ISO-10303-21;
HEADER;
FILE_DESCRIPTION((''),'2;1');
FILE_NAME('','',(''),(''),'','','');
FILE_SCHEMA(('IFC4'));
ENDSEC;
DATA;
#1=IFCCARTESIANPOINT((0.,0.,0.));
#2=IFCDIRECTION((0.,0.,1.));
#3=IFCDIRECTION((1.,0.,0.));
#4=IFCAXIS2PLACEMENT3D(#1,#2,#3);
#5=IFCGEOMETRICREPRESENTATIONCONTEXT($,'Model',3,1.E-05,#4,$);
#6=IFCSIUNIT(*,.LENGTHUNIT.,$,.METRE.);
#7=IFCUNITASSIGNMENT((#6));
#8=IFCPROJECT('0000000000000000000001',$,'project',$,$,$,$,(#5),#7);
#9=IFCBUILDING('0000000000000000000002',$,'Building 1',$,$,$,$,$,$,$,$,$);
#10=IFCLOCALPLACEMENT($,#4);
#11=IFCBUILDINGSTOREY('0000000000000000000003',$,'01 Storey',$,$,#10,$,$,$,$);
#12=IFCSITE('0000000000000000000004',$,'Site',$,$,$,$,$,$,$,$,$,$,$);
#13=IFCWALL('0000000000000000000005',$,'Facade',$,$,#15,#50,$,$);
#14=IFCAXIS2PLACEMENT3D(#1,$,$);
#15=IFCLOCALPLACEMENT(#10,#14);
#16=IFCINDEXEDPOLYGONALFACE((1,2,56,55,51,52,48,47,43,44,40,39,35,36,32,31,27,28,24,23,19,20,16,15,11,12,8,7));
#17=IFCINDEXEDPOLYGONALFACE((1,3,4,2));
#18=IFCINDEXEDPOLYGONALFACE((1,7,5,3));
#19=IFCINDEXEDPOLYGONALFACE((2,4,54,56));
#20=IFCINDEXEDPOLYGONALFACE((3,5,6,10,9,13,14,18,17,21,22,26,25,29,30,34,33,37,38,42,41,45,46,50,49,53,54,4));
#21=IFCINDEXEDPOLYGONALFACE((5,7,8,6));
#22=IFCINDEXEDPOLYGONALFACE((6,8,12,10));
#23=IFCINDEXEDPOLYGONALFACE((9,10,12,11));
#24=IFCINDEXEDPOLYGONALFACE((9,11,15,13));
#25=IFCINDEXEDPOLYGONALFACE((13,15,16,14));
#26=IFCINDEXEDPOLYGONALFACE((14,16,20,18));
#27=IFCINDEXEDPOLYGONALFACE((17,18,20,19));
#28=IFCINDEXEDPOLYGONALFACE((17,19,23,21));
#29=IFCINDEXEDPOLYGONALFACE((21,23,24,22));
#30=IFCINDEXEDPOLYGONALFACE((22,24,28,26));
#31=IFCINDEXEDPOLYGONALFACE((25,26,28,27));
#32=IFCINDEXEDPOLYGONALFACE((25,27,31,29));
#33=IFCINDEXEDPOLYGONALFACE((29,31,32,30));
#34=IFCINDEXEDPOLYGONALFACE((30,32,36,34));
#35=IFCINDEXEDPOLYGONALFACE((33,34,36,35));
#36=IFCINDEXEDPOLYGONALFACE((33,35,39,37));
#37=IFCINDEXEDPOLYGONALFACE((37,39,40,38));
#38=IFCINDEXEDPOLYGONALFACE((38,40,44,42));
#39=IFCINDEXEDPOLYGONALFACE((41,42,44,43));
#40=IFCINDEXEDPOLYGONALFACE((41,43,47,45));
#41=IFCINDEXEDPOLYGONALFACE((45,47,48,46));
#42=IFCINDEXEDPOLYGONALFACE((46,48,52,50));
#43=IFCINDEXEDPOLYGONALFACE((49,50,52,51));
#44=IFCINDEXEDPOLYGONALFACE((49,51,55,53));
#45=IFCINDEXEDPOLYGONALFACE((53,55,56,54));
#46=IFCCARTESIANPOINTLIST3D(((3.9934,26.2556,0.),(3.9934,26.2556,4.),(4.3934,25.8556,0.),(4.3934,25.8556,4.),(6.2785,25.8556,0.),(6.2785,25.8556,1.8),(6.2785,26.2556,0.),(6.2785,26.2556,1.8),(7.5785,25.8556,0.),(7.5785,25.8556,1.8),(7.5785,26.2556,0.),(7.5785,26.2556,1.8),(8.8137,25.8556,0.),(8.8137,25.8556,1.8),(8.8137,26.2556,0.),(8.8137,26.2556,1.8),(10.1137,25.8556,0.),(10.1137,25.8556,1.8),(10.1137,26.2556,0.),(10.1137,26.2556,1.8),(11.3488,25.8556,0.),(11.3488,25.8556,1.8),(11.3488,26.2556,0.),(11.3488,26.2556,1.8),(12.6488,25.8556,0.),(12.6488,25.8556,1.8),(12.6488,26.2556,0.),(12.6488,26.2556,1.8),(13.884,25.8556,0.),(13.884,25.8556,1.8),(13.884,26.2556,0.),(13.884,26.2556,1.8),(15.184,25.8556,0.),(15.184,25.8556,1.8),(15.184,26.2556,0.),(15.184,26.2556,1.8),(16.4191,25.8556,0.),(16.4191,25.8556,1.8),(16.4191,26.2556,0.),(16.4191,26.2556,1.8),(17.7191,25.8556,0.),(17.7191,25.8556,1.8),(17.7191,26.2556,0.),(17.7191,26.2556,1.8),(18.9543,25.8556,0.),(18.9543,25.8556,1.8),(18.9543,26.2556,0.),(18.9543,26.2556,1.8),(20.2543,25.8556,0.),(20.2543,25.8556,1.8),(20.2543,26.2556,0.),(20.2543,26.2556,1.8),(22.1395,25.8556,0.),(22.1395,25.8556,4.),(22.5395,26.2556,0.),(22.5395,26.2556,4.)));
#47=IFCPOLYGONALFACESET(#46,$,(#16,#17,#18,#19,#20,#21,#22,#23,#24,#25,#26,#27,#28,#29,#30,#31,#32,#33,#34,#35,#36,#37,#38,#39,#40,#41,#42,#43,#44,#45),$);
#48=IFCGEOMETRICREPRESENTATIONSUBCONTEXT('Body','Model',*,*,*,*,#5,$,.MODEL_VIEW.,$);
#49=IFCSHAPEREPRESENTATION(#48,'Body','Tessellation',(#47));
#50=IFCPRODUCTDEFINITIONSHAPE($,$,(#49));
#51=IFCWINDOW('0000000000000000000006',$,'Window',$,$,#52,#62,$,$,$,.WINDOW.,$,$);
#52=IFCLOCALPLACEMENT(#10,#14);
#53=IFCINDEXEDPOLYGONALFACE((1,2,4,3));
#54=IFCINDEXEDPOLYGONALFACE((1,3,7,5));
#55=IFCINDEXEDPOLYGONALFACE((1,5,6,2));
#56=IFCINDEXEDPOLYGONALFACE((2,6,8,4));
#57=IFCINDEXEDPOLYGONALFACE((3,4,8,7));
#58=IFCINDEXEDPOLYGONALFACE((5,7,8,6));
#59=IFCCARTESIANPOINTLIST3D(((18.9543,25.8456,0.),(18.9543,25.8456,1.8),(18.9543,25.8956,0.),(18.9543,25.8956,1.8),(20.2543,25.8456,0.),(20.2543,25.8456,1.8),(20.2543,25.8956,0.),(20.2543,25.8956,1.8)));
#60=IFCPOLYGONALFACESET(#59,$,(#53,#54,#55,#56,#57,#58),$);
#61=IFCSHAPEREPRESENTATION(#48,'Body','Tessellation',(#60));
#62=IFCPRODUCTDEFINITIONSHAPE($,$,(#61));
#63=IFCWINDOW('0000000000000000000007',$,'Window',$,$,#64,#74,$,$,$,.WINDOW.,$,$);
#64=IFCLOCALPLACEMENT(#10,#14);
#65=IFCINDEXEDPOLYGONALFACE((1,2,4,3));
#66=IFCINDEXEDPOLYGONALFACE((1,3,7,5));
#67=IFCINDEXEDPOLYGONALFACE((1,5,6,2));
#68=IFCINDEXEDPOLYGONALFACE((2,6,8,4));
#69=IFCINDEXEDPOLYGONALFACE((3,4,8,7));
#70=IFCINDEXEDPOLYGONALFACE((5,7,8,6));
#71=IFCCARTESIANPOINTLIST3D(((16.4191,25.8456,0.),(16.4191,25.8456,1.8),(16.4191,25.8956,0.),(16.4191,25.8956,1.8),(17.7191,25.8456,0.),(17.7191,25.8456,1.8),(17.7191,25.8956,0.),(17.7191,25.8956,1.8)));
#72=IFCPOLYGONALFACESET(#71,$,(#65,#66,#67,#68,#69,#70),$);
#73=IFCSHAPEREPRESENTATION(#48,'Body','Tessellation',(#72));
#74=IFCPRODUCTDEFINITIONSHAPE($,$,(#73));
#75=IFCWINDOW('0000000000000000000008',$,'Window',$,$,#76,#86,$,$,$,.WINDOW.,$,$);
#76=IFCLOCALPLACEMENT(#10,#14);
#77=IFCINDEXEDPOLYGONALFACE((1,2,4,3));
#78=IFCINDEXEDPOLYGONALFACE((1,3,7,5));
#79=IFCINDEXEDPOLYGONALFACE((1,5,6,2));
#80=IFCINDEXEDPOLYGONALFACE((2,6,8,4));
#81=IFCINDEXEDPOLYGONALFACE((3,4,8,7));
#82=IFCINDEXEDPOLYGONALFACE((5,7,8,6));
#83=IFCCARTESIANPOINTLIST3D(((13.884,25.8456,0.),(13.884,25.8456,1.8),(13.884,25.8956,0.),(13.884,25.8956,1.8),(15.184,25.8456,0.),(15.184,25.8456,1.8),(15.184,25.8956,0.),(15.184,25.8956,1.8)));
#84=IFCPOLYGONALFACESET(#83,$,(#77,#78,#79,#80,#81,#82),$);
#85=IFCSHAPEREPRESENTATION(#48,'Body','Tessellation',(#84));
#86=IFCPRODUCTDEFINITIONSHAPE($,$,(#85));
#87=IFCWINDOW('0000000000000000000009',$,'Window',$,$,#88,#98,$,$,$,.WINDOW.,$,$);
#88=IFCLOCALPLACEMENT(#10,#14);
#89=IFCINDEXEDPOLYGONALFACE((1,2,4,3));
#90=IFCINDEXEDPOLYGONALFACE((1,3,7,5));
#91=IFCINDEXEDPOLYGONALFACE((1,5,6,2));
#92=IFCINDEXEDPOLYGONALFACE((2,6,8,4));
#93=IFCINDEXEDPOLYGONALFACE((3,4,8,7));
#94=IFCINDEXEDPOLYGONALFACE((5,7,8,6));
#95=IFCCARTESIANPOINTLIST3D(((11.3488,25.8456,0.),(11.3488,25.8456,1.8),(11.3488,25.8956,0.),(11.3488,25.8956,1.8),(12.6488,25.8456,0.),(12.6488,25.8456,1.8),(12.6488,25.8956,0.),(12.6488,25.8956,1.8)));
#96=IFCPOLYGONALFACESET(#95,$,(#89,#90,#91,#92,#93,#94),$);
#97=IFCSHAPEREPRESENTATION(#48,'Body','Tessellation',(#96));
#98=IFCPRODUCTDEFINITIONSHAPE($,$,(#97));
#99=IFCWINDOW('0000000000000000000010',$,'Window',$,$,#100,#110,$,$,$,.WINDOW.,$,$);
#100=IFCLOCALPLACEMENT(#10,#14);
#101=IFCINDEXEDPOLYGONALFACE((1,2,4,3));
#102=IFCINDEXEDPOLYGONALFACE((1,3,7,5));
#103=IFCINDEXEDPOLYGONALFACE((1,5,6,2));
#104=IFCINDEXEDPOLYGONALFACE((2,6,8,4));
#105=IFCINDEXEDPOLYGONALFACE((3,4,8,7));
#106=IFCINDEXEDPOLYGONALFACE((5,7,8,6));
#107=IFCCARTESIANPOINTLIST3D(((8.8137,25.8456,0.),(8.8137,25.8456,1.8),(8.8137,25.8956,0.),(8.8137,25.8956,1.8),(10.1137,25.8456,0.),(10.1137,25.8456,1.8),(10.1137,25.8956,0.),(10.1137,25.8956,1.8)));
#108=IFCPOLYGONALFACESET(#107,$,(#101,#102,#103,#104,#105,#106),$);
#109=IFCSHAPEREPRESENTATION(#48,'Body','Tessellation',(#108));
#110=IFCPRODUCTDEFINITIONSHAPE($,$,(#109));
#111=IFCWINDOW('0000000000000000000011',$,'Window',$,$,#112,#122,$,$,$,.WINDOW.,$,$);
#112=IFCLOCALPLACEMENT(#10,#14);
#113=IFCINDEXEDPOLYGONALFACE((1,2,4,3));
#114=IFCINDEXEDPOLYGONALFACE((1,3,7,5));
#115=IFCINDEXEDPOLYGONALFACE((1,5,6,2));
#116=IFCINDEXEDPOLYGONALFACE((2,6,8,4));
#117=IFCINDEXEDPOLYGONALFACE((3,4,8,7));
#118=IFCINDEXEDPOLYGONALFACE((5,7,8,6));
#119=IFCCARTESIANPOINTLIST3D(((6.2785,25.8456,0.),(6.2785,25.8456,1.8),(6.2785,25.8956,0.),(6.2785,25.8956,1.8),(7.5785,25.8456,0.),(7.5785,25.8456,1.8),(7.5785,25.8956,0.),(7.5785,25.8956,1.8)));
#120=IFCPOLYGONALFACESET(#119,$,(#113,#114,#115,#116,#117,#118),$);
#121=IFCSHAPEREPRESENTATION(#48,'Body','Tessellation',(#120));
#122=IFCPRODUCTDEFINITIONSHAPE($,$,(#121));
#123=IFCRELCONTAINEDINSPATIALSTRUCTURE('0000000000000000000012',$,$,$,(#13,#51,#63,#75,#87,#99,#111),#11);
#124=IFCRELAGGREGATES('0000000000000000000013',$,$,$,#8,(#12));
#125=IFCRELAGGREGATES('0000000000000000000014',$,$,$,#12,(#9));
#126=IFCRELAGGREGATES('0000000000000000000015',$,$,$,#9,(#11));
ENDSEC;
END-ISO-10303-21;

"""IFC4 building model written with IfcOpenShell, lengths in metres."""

from ifc_helpers import new_model, si_unit, origin_with_axes, place, context, subcontext, project, spatial, line, indexed_curve, outline, extrude, element, fill, save


model = new_model("IFC4")

# Units and contexts
model_context = context("Model", 3, precision=1e-05, world=origin_with_axes())
body_context = subcontext(model_context, "Body", "Model", "MODEL_VIEW")
ifc_project = project(units=[si_unit("LENGTHUNIT", "METRE")], contexts=[model_context])

# Site, building, storey
site = spatial("IfcSite", under=ifc_project, Name="Site")
building = spatial("IfcBuilding", under=site, Name="Building 1")
storey_placement = place(None, origin_with_axes())
storey = spatial("IfcBuildingStorey", under=building, at=storey_placement, Name="01 Storey")

# Wall, openings, windows
wall_1_placement = place(storey_placement, origin_with_axes())
wall_1 = element("IfcWall", 1, at=wall_1_placement, inside=storey, Name="Facade", context=body_context, shape_type="SweptSolid", body=[
    extrude(outline(indexed_curve([(22.1395, 25.8556), (4.3934, 25.8556), (3.9934, 26.2556), (22.5395, 26.2556)], segments=[line(1, 2), line(2, 3), line(3, 4)])), origin_with_axes(), (0.0, 0.0, 1.0), 4.0),
])
opening_1_placement = place(wall_1_placement, origin_with_axes())
opening_1 = element("IfcOpeningElement", 2, at=opening_1_placement, cuts=wall_1, context=body_context, shape_type="SweptSolid", body=[
    extrude(outline(indexed_curve([(20.2543, 26.2956), (20.2543, 25.7956), (18.9543, 25.7956), (18.9543, 26.2956)], segments=[line(1, 2), line(2, 3), line(3, 4)])), origin_with_axes(), (0.0, 0.0, 1.0), 1.8),
])
opening_2_placement = place(wall_1_placement, origin_with_axes())
opening_2 = element("IfcOpeningElement", 3, at=opening_2_placement, cuts=wall_1, context=body_context, shape_type="SweptSolid", body=[
    extrude(outline(indexed_curve([(17.7191, 26.2956), (17.7191, 25.7956), (16.4191, 25.7956), (16.4191, 26.2956)], segments=[line(1, 2), line(2, 3), line(3, 4)])), origin_with_axes(), (0.0, 0.0, 1.0), 1.8),
])
opening_3_placement = place(wall_1_placement, origin_with_axes())
opening_3 = element("IfcOpeningElement", 4, at=opening_3_placement, cuts=wall_1, context=body_context, shape_type="SweptSolid", body=[
    extrude(outline(indexed_curve([(15.184, 26.2956), (15.184, 25.7956), (13.884, 25.7956), (13.884, 26.2956)], segments=[line(1, 2), line(2, 3), line(3, 4)])), origin_with_axes(), (0.0, 0.0, 1.0), 1.8),
])
opening_4_placement = place(wall_1_placement, origin_with_axes())
opening_4 = element("IfcOpeningElement", 5, at=opening_4_placement, cuts=wall_1, context=body_context, shape_type="SweptSolid", body=[
    extrude(outline(indexed_curve([(12.6488, 26.2956), (12.6488, 25.7956), (11.3488, 25.7956), (11.3488, 26.2956)], segments=[line(1, 2), line(2, 3), line(3, 4)])), origin_with_axes(), (0.0, 0.0, 1.0), 1.8),
])
opening_5_placement = place(wall_1_placement, origin_with_axes())
opening_5 = element("IfcOpeningElement", 6, at=opening_5_placement, cuts=wall_1, context=body_context, shape_type="SweptSolid", body=[
    extrude(outline(indexed_curve([(10.1137, 26.2956), (10.1137, 25.7956), (8.8137, 25.7956), (8.8137, 26.2956)], segments=[line(1, 2), line(2, 3), line(3, 4)])), origin_with_axes(), (0.0, 0.0, 1.0), 1.8),
])
opening_6_placement = place(wall_1_placement, origin_with_axes())
opening_6 = element("IfcOpeningElement", 7, at=opening_6_placement, cuts=wall_1, context=body_context, shape_type="SweptSolid", body=[
    extrude(outline(indexed_curve([(7.5785, 26.2956), (7.5785, 25.7956), (6.2785, 25.7956), (6.2785, 26.2956)], segments=[line(1, 2), line(2, 3), line(3, 4)])), origin_with_axes(), (0.0, 0.0, 1.0), 1.8),
])
window_1_placement = place(storey_placement, origin_with_axes())
window_1 = element("IfcWindow", 8, at=window_1_placement, inside=storey, Name="Window", PredefinedType="WINDOW", context=body_context, shape_type="SweptSolid", body=[
    extrude(outline(indexed_curve([(20.2543, 25.8956), (20.2543, 25.8456), (18.9543, 25.8456), (18.9543, 25.8956)], segments=[line(1, 2), line(2, 3), line(3, 4)])), origin_with_axes(), (0.0, 0.0, 1.0), 1.8),
])
fill(opening_1, window_1)
window_2_placement = place(storey_placement, origin_with_axes())
window_2 = element("IfcWindow", 9, at=window_2_placement, inside=storey, Name="Window", PredefinedType="WINDOW", context=body_context, shape_type="SweptSolid", body=[
    extrude(outline(indexed_curve([(17.7191, 25.8956), (17.7191, 25.8456), (16.4191, 25.8456), (16.4191, 25.8956)], segments=[line(1, 2), line(2, 3), line(3, 4)])), origin_with_axes(), (0.0, 0.0, 1.0), 1.8),
])
fill(opening_2, window_2)
window_3_placement = place(storey_placement, origin_with_axes())
window_3 = element("IfcWindow", 10, at=window_3_placement, inside=storey, Name="Window", PredefinedType="WINDOW", context=body_context, shape_type="SweptSolid", body=[
    extrude(outline(indexed_curve([(15.184, 25.8956), (15.184, 25.8456), (13.884, 25.8456), (13.884, 25.8956)], segments=[line(1, 2), line(2, 3), line(3, 4)])), origin_with_axes(), (0.0, 0.0, 1.0), 1.8),
])
fill(opening_3, window_3)
window_4_placement = place(storey_placement, origin_with_axes())
window_4 = element("IfcWindow", 11, at=window_4_placement, inside=storey, Name="Window", PredefinedType="WINDOW", context=body_context, shape_type="SweptSolid", body=[
    extrude(outline(indexed_curve([(12.6488, 25.8956), (12.6488, 25.8456), (11.3488, 25.8456), (11.3488, 25.8956)], segments=[line(1, 2), line(2, 3), line(3, 4)])), origin_with_axes(), (0.0, 0.0, 1.0), 1.8),
])
fill(opening_4, window_4)
window_5_placement = place(storey_placement, origin_with_axes())
window_5 = element("IfcWindow", 12, at=window_5_placement, inside=storey, Name="Window", PredefinedType="WINDOW", context=body_context, shape_type="SweptSolid", body=[
    extrude(outline(indexed_curve([(10.1137, 25.8956), (10.1137, 25.8456), (8.8137, 25.8456), (8.8137, 25.8956)], segments=[line(1, 2), line(2, 3), line(3, 4)])), origin_with_axes(), (0.0, 0.0, 1.0), 1.8),
])
fill(opening_5, window_5)
window_6_placement = place(storey_placement, origin_with_axes())
window_6 = element("IfcWindow", 13, at=window_6_placement, inside=storey, Name="Window", PredefinedType="WINDOW", context=body_context, shape_type="SweptSolid", body=[
    extrude(outline(indexed_curve([(7.5785, 25.8956), (7.5785, 25.8456), (6.2785, 25.8456), (6.2785, 25.8956)], segments=[line(1, 2), line(2, 3), line(3, 4)])), origin_with_axes(), (0.0, 0.0, 1.0), 1.8),
])
fill(opening_6, window_6)

save(model, "model.ifc")
